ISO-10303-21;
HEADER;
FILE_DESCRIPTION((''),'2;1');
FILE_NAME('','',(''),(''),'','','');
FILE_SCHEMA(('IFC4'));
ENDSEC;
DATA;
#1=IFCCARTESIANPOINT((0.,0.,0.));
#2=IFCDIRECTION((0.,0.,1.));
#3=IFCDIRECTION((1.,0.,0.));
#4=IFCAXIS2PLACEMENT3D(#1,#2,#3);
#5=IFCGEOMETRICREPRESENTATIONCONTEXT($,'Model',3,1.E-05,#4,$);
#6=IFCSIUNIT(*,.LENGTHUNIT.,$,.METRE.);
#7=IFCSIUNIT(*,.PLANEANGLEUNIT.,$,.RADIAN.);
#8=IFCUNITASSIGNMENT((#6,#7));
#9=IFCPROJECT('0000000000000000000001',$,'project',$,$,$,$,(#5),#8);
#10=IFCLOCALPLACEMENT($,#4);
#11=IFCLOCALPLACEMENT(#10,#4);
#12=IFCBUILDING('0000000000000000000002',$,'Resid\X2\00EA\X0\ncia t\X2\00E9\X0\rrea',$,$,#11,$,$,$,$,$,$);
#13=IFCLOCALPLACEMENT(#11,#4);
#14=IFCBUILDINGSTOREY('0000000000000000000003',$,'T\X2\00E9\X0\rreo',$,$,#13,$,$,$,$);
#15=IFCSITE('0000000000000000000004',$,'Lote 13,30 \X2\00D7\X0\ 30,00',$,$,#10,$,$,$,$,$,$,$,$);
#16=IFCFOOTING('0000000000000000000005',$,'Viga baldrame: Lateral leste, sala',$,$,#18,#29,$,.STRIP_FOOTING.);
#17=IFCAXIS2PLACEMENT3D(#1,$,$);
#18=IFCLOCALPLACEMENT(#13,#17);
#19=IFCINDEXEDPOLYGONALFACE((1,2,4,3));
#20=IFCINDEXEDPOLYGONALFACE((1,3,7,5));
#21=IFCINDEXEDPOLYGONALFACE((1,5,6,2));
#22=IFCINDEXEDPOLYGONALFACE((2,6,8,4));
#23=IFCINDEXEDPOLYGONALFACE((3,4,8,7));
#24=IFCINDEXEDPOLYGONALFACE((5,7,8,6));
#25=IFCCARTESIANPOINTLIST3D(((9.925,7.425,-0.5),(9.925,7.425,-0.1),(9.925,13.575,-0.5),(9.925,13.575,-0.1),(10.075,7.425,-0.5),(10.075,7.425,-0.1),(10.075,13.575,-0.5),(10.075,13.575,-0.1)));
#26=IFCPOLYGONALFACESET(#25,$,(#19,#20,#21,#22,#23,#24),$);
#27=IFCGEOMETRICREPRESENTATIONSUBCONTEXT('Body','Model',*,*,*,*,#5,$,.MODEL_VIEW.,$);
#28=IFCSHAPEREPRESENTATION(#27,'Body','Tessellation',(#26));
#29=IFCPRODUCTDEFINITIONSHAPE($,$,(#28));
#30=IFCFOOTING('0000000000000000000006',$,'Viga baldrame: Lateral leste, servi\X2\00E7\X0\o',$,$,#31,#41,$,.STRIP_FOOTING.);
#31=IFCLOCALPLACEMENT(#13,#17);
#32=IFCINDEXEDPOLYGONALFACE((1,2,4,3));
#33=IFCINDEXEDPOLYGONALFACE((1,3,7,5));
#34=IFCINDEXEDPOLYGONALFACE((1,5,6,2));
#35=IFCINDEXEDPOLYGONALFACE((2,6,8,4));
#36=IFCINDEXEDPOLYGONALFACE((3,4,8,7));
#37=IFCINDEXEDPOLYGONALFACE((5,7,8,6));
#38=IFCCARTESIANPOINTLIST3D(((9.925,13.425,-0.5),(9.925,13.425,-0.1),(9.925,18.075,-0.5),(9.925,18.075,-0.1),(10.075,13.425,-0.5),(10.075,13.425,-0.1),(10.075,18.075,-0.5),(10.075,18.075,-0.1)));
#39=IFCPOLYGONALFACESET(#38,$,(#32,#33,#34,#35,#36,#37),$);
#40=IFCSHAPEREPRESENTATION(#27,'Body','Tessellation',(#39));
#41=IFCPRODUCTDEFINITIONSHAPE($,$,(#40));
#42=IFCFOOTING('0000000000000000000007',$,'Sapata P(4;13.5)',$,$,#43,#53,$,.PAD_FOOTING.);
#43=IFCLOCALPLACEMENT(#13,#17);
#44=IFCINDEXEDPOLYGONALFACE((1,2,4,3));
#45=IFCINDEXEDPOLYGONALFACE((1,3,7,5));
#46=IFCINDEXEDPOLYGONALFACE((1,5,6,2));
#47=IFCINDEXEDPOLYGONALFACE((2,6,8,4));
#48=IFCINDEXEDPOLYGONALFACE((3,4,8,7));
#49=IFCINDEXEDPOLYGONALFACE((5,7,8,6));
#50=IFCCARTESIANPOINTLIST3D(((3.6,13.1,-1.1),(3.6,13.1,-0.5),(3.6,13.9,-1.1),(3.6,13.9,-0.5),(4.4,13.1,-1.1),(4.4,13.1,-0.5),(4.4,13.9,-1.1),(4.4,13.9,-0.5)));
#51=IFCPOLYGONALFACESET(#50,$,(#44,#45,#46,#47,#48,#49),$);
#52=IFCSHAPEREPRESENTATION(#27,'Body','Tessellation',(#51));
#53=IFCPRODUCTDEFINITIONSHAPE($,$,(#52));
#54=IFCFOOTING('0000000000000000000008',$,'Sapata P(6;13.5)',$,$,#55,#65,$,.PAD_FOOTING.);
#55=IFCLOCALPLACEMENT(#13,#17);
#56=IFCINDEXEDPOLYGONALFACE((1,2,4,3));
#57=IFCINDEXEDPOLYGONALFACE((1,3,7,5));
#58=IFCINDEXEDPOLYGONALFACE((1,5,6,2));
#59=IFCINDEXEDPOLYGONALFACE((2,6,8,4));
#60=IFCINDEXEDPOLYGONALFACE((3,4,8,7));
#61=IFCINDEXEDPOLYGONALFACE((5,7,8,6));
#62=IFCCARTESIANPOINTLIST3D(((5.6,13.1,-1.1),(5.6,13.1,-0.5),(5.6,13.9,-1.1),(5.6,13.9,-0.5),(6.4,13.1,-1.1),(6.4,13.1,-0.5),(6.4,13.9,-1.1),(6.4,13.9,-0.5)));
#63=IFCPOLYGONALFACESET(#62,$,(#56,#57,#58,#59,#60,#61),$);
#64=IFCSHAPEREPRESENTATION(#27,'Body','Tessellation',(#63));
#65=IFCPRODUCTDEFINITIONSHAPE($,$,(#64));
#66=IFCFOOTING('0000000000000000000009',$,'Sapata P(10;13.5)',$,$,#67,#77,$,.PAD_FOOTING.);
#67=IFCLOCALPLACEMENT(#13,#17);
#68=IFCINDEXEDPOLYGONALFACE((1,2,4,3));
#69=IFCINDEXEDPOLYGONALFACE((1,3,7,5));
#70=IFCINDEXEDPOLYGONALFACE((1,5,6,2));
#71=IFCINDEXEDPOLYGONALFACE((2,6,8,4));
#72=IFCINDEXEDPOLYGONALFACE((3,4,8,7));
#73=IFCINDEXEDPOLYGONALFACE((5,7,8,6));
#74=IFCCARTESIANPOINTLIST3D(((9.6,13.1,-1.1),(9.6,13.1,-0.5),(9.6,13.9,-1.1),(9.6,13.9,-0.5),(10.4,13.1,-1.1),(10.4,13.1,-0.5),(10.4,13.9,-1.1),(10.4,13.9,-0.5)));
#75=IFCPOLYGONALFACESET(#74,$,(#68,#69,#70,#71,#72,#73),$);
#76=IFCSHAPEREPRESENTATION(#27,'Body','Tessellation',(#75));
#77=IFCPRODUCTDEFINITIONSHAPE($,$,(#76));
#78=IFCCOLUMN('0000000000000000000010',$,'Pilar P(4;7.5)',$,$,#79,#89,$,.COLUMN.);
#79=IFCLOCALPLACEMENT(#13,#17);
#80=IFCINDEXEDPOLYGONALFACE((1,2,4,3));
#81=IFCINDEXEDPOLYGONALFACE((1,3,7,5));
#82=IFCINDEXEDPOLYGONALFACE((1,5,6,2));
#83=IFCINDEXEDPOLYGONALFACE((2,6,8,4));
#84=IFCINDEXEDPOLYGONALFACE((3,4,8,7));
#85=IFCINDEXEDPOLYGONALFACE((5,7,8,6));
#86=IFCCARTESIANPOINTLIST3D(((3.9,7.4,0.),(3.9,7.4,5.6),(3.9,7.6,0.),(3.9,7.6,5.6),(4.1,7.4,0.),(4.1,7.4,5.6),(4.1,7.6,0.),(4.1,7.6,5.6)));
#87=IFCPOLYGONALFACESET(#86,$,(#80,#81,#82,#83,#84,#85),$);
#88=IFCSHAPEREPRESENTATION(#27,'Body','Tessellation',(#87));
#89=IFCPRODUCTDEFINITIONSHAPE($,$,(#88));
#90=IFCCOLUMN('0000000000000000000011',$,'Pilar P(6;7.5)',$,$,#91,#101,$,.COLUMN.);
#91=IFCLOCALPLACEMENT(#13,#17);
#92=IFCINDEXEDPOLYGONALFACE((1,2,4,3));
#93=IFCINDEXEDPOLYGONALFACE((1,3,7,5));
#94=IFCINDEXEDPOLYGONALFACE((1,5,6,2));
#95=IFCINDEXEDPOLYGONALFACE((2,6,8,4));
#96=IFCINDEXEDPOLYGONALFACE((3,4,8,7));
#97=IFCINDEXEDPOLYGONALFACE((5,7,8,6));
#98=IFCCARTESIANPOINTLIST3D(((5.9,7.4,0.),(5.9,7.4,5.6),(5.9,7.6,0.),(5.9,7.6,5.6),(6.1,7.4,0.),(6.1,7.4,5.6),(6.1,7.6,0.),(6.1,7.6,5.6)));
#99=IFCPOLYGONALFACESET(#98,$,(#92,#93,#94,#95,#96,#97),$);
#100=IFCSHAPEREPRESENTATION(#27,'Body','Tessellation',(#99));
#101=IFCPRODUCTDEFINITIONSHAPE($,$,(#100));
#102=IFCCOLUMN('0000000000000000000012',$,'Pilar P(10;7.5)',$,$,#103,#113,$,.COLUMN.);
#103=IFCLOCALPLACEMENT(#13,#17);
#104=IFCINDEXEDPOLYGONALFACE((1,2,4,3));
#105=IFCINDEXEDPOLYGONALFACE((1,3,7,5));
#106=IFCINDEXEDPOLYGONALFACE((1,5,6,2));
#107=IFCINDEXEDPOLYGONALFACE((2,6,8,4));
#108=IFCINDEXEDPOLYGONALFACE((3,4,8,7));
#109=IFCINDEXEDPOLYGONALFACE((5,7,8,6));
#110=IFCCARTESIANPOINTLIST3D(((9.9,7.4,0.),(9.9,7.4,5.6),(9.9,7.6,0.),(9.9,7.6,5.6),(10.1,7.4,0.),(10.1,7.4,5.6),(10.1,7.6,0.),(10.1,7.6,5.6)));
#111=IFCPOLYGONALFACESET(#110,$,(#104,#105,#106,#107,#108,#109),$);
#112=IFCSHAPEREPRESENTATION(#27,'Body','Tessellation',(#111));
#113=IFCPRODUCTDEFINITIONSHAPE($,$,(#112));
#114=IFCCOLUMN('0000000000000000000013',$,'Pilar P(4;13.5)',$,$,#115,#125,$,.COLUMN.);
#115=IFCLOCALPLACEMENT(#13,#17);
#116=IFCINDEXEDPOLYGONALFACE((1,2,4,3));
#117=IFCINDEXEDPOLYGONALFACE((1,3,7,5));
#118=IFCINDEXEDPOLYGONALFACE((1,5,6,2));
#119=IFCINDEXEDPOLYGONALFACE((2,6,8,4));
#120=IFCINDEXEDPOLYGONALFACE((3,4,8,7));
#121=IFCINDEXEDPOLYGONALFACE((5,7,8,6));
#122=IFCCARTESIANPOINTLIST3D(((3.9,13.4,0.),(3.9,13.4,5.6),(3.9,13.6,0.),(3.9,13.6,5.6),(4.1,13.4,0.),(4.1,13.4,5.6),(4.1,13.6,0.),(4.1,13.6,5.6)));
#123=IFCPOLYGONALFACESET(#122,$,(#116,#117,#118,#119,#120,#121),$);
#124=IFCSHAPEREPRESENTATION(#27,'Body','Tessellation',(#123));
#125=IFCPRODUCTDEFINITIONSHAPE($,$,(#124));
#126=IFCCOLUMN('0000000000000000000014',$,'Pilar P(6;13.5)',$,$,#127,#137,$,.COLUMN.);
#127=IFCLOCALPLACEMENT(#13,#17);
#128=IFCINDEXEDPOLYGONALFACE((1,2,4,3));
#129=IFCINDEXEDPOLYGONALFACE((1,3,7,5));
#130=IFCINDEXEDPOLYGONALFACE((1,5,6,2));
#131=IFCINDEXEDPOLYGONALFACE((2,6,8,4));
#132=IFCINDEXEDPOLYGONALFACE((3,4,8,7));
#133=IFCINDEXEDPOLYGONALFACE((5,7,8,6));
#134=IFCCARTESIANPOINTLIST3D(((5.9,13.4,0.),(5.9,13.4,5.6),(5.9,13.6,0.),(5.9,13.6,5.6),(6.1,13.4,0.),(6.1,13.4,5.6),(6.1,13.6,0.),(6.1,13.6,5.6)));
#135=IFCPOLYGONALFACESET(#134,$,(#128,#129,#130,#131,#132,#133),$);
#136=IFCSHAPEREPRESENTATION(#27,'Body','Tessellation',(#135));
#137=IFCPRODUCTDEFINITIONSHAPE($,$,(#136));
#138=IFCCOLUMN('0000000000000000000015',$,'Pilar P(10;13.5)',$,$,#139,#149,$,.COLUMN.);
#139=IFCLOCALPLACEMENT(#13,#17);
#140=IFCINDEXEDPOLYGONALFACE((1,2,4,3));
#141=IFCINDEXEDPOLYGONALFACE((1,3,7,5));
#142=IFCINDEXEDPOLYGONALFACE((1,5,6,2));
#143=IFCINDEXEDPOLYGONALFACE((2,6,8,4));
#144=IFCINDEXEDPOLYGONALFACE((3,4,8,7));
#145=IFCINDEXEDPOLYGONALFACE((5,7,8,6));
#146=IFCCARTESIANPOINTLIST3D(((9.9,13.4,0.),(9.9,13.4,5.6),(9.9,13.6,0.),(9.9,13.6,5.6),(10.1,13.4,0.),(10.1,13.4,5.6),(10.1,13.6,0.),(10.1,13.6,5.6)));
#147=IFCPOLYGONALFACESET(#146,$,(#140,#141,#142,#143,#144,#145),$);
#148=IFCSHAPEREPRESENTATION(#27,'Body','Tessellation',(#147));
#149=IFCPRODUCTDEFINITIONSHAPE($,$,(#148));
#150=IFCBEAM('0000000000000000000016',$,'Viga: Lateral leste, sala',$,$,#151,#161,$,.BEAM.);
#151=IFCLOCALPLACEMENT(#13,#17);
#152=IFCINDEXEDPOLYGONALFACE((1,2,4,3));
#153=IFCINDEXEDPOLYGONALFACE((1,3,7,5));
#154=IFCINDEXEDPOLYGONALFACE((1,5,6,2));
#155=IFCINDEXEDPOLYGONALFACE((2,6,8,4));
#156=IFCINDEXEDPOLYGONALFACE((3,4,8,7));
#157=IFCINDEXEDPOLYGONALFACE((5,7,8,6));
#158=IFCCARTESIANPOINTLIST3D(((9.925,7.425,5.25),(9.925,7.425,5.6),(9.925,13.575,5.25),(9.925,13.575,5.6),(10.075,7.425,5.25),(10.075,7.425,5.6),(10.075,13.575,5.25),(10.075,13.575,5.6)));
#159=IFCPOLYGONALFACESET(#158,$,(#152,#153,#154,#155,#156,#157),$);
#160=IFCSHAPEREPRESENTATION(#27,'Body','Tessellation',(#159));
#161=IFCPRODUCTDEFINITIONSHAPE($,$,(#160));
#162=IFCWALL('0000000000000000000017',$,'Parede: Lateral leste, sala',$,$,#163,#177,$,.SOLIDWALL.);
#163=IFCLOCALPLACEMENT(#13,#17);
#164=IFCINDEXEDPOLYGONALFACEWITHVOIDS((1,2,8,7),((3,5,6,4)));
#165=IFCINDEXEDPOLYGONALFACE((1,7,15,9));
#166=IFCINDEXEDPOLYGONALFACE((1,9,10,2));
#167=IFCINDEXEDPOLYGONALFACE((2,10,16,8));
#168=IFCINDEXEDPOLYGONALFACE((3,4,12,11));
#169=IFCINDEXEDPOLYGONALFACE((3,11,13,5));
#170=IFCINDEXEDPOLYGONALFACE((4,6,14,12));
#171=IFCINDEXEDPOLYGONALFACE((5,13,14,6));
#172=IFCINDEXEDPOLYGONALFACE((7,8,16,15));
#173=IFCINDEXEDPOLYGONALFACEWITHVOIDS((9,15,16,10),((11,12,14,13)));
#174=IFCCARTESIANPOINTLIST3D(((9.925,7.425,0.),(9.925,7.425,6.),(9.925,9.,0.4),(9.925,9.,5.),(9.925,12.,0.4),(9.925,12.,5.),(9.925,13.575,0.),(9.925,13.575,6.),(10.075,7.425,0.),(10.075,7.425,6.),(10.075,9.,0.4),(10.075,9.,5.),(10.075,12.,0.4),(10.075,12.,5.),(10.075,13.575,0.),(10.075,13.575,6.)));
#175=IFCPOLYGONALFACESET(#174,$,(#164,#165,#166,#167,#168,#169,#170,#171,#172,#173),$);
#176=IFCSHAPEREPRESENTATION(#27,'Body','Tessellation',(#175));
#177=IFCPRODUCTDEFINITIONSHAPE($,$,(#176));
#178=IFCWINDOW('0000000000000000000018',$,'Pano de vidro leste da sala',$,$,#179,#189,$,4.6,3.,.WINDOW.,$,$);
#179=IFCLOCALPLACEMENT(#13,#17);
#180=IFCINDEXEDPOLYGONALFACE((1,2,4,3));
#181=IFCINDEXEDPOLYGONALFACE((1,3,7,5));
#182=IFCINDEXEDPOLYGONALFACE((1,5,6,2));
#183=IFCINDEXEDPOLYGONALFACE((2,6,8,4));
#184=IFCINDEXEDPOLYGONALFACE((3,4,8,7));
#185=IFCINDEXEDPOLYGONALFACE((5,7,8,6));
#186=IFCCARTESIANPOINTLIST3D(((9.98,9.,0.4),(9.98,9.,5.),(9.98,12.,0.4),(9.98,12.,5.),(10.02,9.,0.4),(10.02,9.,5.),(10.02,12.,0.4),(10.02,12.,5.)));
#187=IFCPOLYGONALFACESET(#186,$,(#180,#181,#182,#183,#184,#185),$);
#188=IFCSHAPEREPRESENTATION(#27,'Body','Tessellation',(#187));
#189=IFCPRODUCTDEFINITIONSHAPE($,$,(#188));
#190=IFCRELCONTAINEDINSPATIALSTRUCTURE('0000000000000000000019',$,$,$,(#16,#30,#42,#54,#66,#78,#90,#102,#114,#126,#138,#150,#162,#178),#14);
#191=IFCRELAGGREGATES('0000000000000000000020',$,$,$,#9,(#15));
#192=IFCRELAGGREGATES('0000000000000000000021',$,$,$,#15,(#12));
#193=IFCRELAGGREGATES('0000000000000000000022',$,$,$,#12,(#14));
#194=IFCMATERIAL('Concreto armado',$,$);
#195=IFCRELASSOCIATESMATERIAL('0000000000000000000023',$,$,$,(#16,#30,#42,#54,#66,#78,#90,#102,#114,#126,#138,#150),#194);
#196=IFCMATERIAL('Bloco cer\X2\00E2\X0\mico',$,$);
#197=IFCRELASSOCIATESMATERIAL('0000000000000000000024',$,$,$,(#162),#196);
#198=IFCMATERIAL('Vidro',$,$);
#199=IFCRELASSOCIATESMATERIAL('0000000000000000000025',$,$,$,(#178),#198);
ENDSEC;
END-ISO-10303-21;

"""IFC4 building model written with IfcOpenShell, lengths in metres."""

from ifc_helpers import new_model, si_unit, frame, origin_with_axes, place, context, subcontext, project, spatial, line, indexed_curve, outline, extrude, material, element, fill, save


model = new_model("IFC4")

# Units and contexts
model_context = context("Model", 3, precision=1e-05, world=origin_with_axes())
body_context = subcontext(model_context, "Body", "Model", "MODEL_VIEW")
ifc_project = project(units=[si_unit("LENGTHUNIT", "METRE"), si_unit("PLANEANGLEUNIT", "RADIAN")], contexts=[model_context])

# Site, building, storey
site_placement = place(None, origin_with_axes())
site = spatial("IfcSite", under=ifc_project, at=site_placement, Name="Lote 13,30 × 30,00")
building_placement = place(site_placement, origin_with_axes())
building = spatial("IfcBuilding", under=site, at=building_placement, Name="Residência térrea")
storey_placement = place(building_placement, origin_with_axes())
storey = spatial("IfcBuildingStorey", under=building, at=storey_placement, Name="Térreo")

# Footings
ifc_material_1 = material(Name="Concreto armado")
footing_1_placement = place(storey_placement, frame((9.925, 7.425, -0.5), z_axis=(0.0, 0.0, 1.0), x_axis=(1.0, 0.0, 0.0)))
element("IfcFooting", 1, at=footing_1_placement, inside=storey, material=ifc_material_1, Name="Viga baldrame: Lateral leste, sala", PredefinedType="STRIP_FOOTING", context=body_context, shape_type="SweptSolid", body=[
    extrude(outline(indexed_curve([(0.0, 0.0), (0.15, 0.0), (0.15, 6.15), (0.0, 6.15)], segments=[line(1, 2, 3, 4, 1)])), origin_with_axes(), (0.0, 0.0, 1.0), 0.4),
])
footing_2_placement = place(storey_placement, frame((9.925, 13.425, -0.5), z_axis=(0.0, 0.0, 1.0), x_axis=(1.0, 0.0, 0.0)))
element("IfcFooting", 2, at=footing_2_placement, inside=storey, material=ifc_material_1, Name="Viga baldrame: Lateral leste, serviço", PredefinedType="STRIP_FOOTING", context=body_context, shape_type="SweptSolid", body=[
    extrude(outline(indexed_curve([(0.0, 0.0), (0.15, 0.0), (0.15, 4.65), (0.0, 4.65)], segments=[line(1, 2, 3, 4, 1)])), origin_with_axes(), (0.0, 0.0, 1.0), 0.4),
])
footing_3_placement = place(storey_placement, frame((3.6, 13.1, -1.1), z_axis=(0.0, 0.0, 1.0), x_axis=(1.0, 0.0, 0.0)))
element("IfcFooting", 3, at=footing_3_placement, inside=storey, material=ifc_material_1, Name="Sapata P(4;13.5)", PredefinedType="PAD_FOOTING", context=body_context, shape_type="SweptSolid", body=[
    extrude(outline(indexed_curve([(0.0, 0.0), (0.8, 0.0), (0.8, 0.8), (0.0, 0.8)], segments=[line(1, 2, 3, 4, 1)])), origin_with_axes(), (0.0, 0.0, 1.0), 0.6),
])
for number, where, z_axis, x_axis, name in (
    (4, (5.6, 13.1, -1.1), (0.0, 0.0, 1.0), (1.0, 0.0, 0.0), "Sapata P(6;13.5)"),
    (5, (9.6, 13.1, -1.1), (0.0, 0.0, 1.0), (1.0, 0.0, 0.0), "Sapata P(10;13.5)"),
):
    element("IfcFooting", number, at=place(storey_placement, frame(where, z_axis=z_axis, x_axis=x_axis)), inside=storey, material=ifc_material_1, Name=name, PredefinedType="PAD_FOOTING", context=body_context, shape_type="SweptSolid", body=[
        extrude(outline(indexed_curve([(0.0, 0.0), (0.8, 0.0), (0.8, 0.8), (0.0, 0.8)], segments=[line(1, 2, 3, 4, 1)])), origin_with_axes(), (0.0, 0.0, 1.0), 0.6),
    ])

# Columns
column_1_placement = place(storey_placement, frame((3.9, 7.4, 0.0), z_axis=(0.0, 0.0, 1.0), x_axis=(1.0, 0.0, 0.0)))
element("IfcColumn", 6, at=column_1_placement, inside=storey, material=ifc_material_1, Name="Pilar P(4;7.5)", PredefinedType="COLUMN", context=body_context, shape_type="SweptSolid", body=[
    extrude(outline(indexed_curve([(0.0, 0.0), (0.2, 0.0), (0.2, 0.2), (0.0, 0.2)], segments=[line(1, 2, 3, 4, 1)])), origin_with_axes(), (0.0, 0.0, 1.0), 5.6),
])
for number, where, z_axis, x_axis, name in (
    (7, (5.9, 7.4, 0.0), (0.0, 0.0, 1.0), (1.0, 0.0, 0.0), "Pilar P(6;7.5)"),
    (8, (9.9, 7.4, 0.0), (0.0, 0.0, 1.0), (1.0, 0.0, 0.0), "Pilar P(10;7.5)"),
):
    element("IfcColumn", number, at=place(storey_placement, frame(where, z_axis=z_axis, x_axis=x_axis)), inside=storey, material=ifc_material_1, Name=name, PredefinedType="COLUMN", context=body_context, shape_type="SweptSolid", body=[
        extrude(outline(indexed_curve([(0.0, 0.0), (0.2, 0.0), (0.2, 0.2), (0.0, 0.2)], segments=[line(1, 2, 3, 4, 1)])), origin_with_axes(), (0.0, 0.0, 1.0), 5.6),
    ])
column_2_placement = place(storey_placement, frame((3.9, 13.4, 0.0), z_axis=(0.0, 0.0, 1.0), x_axis=(1.0, 0.0, 0.0)))
element("IfcColumn", 9, at=column_2_placement, inside=storey, material=ifc_material_1, Name="Pilar P(4;13.5)", PredefinedType="COLUMN", context=body_context, shape_type="SweptSolid", body=[
    extrude(outline(indexed_curve([(0.0, 0.0), (0.2, 0.0), (0.2, 0.2), (0.0, 0.2)], segments=[line(1, 2, 3, 4, 1)])), origin_with_axes(), (0.0, 0.0, 1.0), 5.6),
])
for number, where, z_axis, x_axis, name in (
    (10, (5.9, 13.4, 0.0), (0.0, 0.0, 1.0), (1.0, 0.0, 0.0), "Pilar P(6;13.5)"),
    (11, (9.9, 13.4, 0.0), (0.0, 0.0, 1.0), (1.0, 0.0, 0.0), "Pilar P(10;13.5)"),
):
    element("IfcColumn", number, at=place(storey_placement, frame(where, z_axis=z_axis, x_axis=x_axis)), inside=storey, material=ifc_material_1, Name=name, PredefinedType="COLUMN", context=body_context, shape_type="SweptSolid", body=[
        extrude(outline(indexed_curve([(0.0, 0.0), (0.2, 0.0), (0.2, 0.2), (0.0, 0.2)], segments=[line(1, 2, 3, 4, 1)])), origin_with_axes(), (0.0, 0.0, 1.0), 5.6),
    ])

# Beam
beam_placement = place(storey_placement, frame((9.925, 7.425, 5.25), z_axis=(0.0, 0.0, 1.0), x_axis=(1.0, 0.0, 0.0)))
element("IfcBeam", 12, at=beam_placement, inside=storey, material=ifc_material_1, Name="Viga: Lateral leste, sala", PredefinedType="BEAM", context=body_context, shape_type="SweptSolid", body=[
    extrude(outline(indexed_curve([(0.0, 0.0), (0.15, 0.0), (0.15, 6.15), (0.0, 6.15)], segments=[line(1, 2, 3, 4, 1)])), origin_with_axes(), (0.0, 0.0, 1.0), 0.35),
])

# Wall, opening, window
ifc_material_2 = material(Name="Bloco cerâmico")
wall_1_placement = place(storey_placement, frame((9.925, 7.425, 0.0), z_axis=(0.0, 0.0, 1.0), x_axis=(1.0, 0.0, 0.0)))
wall_1 = element("IfcWall", 13, at=wall_1_placement, inside=storey, material=ifc_material_2, Name="Parede: Lateral leste, sala", PredefinedType="SOLIDWALL", context=body_context, shape_type="SweptSolid", body=[
    extrude(outline(indexed_curve([(0.0, 0.0), (0.15, 0.0), (0.15, 6.15), (0.0, 6.15)], segments=[line(1, 2, 3, 4, 1)])), origin_with_axes(), (0.0, 0.0, 1.0), 6.0),
])
opening_1_placement = place(wall_1_placement, frame((-0.05, 1.575, 0.4), z_axis=(0.0, 0.0, 1.0), x_axis=(1.0, 0.0, 0.0)))
opening_1 = element("IfcOpeningElement", 14, at=opening_1_placement, cuts=wall_1, material=ifc_material_1, PredefinedType="OPENING", context=body_context, shape_type="SweptSolid", body=[
    extrude(outline(indexed_curve([(0.0, 0.0), (0.25, 0.0), (0.25, 3.0), (0.0, 3.0)], segments=[line(1, 2, 3, 4, 1)])), origin_with_axes(), (0.0, 0.0, 1.0), 4.6),
])
ifc_material_3 = material(Name="Vidro")
window_1_placement = place(storey_placement, frame((9.98, 9.0, 0.4), z_axis=(0.0, 0.0, 1.0), x_axis=(1.0, 0.0, 0.0)))
window_1 = element("IfcWindow", 15, at=window_1_placement, inside=storey, material=ifc_material_3, Name="Pano de vidro leste da sala", OverallHeight=4.6, OverallWidth=3.0, PredefinedType="WINDOW", context=body_context, shape_type="SweptSolid", body=[
    extrude(outline(indexed_curve([(0.0, 0.0), (0.04, 0.0), (0.04, 3.0), (0.0, 3.0)], segments=[line(1, 2, 3, 4, 1)])), origin_with_axes(), (0.0, 0.0, 1.0), 4.6),
])
fill(opening_1, window_1)

save(model, "model.ifc")
